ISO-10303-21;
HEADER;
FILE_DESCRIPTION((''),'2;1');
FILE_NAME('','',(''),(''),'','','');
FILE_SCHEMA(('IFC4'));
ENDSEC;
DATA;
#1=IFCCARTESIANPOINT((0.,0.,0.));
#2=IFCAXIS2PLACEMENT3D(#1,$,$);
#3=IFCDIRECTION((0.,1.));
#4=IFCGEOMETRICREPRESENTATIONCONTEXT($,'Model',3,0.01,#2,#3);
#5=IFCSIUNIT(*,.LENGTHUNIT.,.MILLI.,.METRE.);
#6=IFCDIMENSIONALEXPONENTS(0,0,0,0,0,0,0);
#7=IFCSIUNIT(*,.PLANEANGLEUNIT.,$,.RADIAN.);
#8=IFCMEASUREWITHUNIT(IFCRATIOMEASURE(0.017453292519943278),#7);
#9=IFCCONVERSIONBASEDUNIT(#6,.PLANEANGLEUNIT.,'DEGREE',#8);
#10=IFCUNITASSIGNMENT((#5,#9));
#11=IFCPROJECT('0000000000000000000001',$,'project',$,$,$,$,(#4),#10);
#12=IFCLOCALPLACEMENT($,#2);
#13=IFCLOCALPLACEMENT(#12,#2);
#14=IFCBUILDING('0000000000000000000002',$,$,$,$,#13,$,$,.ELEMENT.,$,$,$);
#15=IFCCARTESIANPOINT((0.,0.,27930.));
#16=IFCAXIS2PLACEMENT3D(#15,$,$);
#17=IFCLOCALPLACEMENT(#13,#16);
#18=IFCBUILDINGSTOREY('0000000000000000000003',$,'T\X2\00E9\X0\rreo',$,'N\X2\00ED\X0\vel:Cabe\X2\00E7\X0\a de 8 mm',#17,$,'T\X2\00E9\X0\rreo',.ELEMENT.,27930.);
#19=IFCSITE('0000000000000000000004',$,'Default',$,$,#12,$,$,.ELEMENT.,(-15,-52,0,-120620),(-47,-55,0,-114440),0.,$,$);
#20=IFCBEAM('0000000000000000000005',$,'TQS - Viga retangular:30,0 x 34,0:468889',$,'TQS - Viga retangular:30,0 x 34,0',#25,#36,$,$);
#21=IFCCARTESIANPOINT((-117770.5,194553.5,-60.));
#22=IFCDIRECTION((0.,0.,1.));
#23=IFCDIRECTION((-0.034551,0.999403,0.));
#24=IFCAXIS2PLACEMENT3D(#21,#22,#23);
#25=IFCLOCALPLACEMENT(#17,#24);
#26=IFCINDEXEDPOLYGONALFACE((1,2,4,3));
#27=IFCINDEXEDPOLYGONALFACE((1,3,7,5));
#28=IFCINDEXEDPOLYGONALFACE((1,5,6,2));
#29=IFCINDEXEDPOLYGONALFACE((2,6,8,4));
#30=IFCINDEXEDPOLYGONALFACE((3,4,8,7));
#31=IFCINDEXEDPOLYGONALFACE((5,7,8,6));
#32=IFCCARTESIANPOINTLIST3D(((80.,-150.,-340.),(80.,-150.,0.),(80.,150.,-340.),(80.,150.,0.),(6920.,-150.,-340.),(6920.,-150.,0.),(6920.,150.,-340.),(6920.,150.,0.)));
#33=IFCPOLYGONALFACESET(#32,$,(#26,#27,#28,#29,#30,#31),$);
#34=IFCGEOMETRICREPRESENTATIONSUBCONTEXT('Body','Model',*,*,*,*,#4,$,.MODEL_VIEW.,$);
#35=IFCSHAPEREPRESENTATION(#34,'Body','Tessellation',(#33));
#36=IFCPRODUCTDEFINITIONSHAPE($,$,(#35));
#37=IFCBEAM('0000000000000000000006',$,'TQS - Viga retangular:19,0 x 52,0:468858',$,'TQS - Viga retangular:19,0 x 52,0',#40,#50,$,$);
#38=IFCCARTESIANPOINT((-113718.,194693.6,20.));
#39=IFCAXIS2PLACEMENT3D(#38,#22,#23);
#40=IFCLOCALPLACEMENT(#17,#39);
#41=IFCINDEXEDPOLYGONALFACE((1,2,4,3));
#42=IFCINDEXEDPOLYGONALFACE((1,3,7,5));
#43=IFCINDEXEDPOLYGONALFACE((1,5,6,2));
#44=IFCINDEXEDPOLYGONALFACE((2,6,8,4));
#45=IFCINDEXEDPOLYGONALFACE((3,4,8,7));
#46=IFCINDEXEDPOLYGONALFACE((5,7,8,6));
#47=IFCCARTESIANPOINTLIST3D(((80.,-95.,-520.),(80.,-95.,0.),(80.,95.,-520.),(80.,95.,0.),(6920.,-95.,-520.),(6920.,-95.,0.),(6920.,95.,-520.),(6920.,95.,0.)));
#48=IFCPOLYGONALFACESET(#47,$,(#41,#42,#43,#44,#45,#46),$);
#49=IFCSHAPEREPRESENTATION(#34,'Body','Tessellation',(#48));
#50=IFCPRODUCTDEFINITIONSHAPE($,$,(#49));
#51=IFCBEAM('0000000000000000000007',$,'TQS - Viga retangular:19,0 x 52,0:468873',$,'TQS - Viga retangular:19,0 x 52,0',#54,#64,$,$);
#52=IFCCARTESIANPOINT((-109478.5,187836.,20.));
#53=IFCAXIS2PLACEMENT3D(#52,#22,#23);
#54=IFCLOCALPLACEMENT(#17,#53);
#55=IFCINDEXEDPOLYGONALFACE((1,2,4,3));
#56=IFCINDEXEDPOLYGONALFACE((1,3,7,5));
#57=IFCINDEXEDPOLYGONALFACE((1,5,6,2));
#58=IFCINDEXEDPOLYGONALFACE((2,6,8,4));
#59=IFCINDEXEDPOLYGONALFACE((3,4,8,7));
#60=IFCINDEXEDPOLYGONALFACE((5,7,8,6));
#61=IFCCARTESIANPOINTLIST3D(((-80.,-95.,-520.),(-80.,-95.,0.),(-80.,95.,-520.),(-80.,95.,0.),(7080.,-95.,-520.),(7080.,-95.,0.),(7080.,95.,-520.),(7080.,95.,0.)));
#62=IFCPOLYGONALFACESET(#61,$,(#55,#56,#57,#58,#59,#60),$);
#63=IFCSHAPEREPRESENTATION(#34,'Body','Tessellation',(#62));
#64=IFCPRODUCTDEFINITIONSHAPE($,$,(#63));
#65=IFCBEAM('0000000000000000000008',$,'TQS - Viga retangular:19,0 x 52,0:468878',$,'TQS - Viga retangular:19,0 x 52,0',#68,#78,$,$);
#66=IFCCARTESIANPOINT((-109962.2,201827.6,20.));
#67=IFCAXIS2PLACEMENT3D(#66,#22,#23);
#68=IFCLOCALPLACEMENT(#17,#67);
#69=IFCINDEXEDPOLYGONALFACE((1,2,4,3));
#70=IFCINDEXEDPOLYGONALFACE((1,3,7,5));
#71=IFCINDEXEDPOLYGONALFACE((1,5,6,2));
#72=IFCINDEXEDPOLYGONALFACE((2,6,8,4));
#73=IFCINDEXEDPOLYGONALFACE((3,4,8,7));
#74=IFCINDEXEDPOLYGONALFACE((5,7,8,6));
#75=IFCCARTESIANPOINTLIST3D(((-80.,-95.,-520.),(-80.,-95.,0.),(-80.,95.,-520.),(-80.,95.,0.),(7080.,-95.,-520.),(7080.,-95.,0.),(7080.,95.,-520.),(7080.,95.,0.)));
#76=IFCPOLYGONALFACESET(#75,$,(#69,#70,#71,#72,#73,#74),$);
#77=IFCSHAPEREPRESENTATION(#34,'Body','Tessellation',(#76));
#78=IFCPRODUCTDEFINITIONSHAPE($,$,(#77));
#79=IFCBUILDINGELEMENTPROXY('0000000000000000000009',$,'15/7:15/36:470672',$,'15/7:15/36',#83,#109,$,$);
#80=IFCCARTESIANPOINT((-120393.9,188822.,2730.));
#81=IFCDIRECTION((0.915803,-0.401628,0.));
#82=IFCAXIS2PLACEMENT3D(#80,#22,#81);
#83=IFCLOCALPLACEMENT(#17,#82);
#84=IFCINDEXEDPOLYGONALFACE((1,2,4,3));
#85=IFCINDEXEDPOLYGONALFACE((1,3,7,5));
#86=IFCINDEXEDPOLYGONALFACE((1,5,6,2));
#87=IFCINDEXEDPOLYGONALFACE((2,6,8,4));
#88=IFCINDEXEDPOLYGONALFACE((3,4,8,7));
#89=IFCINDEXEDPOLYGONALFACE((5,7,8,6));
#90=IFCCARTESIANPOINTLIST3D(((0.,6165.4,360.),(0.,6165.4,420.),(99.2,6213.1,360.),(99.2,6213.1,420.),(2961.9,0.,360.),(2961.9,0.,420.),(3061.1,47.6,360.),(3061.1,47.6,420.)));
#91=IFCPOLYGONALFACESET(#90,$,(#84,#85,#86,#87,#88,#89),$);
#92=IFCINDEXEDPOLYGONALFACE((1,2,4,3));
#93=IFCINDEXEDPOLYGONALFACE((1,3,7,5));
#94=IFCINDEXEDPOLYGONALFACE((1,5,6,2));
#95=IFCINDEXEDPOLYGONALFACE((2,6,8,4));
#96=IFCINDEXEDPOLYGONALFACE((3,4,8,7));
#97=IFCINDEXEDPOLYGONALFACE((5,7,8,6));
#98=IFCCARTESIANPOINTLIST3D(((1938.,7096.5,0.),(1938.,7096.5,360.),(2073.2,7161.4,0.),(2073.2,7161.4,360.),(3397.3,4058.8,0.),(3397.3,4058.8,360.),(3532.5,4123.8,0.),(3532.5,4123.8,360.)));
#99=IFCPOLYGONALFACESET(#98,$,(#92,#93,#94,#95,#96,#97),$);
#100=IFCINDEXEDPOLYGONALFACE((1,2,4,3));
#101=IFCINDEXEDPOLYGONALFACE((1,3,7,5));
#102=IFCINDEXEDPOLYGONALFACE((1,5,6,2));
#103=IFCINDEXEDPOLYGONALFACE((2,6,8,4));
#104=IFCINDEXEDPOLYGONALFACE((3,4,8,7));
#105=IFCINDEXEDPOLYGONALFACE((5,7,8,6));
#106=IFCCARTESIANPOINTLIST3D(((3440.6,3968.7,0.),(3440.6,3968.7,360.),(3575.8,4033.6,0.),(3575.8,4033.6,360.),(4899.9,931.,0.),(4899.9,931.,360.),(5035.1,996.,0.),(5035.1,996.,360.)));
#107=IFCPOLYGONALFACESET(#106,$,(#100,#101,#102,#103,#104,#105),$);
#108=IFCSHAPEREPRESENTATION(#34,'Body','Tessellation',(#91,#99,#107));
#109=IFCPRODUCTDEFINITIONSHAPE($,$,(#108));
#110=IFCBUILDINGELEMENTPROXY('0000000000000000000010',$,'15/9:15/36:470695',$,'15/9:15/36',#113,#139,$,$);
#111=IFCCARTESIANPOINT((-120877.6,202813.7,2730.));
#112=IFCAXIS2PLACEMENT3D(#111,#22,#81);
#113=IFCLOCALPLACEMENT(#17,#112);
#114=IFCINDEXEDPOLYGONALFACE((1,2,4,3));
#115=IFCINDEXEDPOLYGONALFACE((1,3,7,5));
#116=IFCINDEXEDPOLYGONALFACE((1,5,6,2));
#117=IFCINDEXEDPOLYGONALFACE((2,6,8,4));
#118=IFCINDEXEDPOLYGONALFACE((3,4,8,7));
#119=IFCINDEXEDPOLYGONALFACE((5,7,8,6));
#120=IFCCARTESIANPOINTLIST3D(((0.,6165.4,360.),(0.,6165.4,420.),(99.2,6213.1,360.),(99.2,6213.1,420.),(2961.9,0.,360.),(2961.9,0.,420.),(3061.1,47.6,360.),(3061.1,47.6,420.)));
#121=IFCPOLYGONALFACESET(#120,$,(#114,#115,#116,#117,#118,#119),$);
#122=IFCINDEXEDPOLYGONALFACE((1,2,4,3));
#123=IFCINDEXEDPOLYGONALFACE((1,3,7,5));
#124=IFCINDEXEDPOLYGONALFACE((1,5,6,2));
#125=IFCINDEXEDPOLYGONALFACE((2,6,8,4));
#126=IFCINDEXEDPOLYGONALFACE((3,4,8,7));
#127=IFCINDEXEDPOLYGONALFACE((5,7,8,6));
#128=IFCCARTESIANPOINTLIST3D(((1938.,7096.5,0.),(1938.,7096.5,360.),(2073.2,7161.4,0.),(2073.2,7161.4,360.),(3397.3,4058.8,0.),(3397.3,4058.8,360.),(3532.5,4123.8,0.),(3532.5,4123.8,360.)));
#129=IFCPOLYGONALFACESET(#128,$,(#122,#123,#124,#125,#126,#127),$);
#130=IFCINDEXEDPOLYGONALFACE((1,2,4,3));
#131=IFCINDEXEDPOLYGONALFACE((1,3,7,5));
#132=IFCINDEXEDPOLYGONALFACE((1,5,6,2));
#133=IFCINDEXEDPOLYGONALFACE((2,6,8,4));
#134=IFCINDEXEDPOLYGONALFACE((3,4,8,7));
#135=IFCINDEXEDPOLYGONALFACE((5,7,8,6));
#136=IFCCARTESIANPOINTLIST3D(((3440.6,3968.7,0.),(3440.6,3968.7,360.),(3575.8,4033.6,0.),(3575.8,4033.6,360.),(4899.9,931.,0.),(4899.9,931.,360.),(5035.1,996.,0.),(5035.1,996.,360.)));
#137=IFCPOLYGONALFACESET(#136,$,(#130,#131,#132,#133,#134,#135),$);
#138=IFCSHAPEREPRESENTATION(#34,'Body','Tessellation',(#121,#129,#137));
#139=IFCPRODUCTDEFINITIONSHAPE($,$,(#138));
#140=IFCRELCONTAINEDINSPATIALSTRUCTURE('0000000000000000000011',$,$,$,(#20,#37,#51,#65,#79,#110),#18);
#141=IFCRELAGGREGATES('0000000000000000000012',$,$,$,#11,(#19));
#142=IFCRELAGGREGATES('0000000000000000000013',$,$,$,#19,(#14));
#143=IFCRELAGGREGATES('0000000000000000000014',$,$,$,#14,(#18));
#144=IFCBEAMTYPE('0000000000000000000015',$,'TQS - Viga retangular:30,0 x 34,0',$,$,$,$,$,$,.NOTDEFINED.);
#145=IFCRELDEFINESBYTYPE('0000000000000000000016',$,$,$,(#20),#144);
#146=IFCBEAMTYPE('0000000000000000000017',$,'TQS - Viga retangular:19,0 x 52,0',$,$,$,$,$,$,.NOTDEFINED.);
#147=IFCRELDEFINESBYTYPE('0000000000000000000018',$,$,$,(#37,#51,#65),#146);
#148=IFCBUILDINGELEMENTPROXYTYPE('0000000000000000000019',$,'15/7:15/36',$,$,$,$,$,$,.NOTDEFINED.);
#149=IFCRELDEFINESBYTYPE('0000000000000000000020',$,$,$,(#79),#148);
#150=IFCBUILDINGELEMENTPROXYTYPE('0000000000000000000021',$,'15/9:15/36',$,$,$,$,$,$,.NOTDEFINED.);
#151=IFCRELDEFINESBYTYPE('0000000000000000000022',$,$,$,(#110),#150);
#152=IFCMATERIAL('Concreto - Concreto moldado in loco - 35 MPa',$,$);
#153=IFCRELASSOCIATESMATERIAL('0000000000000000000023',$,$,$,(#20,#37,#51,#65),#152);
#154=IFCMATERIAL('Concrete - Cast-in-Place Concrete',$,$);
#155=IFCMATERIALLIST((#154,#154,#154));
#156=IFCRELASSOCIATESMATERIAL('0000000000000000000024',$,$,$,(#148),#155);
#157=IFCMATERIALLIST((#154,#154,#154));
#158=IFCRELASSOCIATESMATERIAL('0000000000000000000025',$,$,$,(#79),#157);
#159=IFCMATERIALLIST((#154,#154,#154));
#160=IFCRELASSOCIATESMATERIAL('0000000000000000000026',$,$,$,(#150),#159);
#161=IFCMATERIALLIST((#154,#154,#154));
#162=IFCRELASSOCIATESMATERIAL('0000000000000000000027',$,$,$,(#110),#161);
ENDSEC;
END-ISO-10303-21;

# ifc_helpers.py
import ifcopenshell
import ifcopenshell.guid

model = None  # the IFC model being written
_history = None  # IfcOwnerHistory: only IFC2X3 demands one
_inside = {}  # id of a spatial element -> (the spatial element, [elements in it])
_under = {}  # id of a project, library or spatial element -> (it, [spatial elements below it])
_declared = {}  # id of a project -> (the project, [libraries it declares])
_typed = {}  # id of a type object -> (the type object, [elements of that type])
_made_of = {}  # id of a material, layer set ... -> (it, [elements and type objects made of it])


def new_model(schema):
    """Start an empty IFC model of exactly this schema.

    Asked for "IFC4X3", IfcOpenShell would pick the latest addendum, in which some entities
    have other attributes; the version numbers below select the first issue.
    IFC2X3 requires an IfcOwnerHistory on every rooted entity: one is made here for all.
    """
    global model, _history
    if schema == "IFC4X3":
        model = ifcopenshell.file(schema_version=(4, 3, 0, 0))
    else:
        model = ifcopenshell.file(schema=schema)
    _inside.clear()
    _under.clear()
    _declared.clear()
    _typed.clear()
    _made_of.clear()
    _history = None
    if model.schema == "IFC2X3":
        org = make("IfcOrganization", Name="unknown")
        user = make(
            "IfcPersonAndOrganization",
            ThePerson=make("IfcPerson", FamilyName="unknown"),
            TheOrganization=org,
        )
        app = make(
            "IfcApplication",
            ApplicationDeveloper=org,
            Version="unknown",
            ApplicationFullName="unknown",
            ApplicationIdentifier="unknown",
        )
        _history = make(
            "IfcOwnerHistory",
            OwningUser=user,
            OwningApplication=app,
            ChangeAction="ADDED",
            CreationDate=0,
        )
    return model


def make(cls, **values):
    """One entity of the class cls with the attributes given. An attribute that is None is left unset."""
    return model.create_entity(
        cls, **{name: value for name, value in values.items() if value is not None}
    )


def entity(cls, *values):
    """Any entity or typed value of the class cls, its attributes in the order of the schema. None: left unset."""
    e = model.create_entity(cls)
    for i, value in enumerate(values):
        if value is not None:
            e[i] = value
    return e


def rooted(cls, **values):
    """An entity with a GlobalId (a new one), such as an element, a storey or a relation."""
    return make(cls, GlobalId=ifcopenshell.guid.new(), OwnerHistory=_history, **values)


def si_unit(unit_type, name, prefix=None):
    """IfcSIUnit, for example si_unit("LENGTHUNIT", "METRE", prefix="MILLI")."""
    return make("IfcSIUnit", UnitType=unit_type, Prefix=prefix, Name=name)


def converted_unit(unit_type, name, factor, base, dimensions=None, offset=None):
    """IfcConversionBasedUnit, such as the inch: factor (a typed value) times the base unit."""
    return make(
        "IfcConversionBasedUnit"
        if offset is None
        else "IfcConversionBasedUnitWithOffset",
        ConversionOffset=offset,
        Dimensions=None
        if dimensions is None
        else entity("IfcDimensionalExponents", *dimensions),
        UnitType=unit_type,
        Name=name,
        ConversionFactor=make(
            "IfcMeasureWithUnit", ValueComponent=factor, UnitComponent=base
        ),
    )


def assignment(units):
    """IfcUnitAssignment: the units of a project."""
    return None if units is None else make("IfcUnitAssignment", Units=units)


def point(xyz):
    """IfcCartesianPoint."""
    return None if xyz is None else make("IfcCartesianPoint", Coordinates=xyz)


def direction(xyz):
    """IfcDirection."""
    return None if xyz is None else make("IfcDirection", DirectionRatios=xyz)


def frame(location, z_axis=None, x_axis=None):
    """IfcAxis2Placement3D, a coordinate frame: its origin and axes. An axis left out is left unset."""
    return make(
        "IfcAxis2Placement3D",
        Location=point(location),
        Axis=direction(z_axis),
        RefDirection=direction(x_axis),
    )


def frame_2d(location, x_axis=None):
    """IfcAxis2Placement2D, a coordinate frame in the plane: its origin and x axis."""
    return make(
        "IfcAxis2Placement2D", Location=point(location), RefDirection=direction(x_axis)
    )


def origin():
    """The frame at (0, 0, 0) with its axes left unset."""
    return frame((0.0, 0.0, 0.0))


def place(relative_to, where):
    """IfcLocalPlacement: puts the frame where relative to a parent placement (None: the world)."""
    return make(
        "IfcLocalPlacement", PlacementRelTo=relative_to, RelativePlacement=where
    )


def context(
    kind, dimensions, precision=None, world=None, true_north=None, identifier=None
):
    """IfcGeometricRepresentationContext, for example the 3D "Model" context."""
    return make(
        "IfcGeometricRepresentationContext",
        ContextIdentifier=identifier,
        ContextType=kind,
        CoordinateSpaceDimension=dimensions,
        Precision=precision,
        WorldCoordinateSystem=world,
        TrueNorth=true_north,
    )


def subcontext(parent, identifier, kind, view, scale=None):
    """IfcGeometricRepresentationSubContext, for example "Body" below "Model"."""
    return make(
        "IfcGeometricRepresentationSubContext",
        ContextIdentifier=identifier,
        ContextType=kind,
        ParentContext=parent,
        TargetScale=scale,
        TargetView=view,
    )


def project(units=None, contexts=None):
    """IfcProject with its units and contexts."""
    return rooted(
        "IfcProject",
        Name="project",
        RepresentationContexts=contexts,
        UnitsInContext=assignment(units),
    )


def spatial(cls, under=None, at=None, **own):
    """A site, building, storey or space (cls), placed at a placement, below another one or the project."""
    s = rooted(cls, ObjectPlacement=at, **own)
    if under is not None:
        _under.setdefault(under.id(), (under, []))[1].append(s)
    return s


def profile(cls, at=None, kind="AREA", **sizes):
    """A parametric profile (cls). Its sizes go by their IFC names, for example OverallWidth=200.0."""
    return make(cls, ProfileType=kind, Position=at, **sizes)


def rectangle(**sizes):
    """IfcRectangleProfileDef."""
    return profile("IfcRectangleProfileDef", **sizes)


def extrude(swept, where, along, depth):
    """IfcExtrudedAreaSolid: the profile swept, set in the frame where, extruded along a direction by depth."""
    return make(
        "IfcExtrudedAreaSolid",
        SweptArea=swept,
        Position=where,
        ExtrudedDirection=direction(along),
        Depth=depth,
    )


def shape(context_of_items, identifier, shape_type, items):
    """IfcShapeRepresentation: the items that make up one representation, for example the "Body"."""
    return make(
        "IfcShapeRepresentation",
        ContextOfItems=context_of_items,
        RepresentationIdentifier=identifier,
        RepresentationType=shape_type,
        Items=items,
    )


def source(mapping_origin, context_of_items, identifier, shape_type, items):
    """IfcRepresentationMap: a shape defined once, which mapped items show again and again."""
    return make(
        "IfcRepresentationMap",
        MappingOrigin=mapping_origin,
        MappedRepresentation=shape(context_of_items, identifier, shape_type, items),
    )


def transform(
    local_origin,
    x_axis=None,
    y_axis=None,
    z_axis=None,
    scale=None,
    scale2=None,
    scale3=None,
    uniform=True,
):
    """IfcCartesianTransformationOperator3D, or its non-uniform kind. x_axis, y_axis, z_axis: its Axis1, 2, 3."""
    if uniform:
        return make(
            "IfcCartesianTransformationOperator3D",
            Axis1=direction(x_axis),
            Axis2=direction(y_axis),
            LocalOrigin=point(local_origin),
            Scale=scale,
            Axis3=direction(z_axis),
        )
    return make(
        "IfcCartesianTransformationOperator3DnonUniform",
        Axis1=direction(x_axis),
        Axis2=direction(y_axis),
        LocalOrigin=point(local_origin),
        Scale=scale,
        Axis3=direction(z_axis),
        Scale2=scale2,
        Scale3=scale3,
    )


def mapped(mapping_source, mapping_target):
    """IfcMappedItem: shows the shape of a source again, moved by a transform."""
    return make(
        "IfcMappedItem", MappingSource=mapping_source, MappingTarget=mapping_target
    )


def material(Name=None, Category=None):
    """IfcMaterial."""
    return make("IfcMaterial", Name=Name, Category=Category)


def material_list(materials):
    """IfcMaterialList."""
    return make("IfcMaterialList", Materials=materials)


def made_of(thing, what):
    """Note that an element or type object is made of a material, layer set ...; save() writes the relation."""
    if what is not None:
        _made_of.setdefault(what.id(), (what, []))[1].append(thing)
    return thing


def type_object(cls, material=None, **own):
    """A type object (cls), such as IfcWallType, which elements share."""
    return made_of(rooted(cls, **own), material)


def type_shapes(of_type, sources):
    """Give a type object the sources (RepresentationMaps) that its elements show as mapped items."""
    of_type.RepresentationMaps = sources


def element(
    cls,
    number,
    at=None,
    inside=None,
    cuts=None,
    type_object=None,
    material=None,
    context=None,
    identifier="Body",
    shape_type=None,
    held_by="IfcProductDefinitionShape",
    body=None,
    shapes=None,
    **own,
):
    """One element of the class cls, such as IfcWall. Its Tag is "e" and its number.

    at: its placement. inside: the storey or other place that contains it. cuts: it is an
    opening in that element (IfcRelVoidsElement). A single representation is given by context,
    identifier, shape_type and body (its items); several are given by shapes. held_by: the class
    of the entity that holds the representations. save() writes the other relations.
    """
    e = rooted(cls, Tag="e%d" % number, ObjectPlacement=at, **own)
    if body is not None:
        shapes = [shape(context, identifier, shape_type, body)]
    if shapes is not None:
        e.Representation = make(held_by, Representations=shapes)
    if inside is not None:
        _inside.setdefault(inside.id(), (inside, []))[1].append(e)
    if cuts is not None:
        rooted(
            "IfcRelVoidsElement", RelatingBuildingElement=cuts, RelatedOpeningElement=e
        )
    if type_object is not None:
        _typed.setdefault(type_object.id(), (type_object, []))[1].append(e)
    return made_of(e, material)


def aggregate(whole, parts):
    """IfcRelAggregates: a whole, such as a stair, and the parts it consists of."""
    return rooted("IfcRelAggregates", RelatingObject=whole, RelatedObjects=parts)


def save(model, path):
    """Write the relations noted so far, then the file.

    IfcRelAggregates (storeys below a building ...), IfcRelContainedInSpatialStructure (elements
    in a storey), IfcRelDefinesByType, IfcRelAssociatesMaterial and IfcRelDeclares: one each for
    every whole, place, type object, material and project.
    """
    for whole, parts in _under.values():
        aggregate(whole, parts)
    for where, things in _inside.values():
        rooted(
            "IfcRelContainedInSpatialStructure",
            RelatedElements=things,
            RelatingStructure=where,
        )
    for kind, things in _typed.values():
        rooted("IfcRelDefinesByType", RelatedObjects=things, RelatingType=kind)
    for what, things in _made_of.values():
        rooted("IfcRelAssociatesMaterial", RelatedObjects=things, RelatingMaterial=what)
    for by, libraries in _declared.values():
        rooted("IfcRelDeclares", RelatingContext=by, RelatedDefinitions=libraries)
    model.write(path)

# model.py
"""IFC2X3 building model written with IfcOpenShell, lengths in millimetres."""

from ifc_helpers import new_model, entity, si_unit, converted_unit, direction, frame, frame_2d, origin, place, context, subcontext, project, spatial, rectangle, extrude, source, transform, mapped, material, material_list, type_object, type_shapes, element, save


model = new_model("IFC2X3")

# Units and contexts
model_context = context("Model", 3, precision=0.01, world=origin(), true_north=direction((0.0, 1.0)))
body_context = subcontext(model_context, "Body", "Model", "MODEL_VIEW")
ifc_project = project(units=[si_unit("LENGTHUNIT", "METRE", prefix="MILLI"), converted_unit("PLANEANGLEUNIT", "DEGREE", entity("IfcRatioMeasure", 0.017453292519943278), si_unit("PLANEANGLEUNIT", "RADIAN"), dimensions=[0, 0, 0, 0, 0, 0, 0])], contexts=[model_context])

# Site, building, storey
site_placement = place(None, origin())
site = spatial("IfcSite", under=ifc_project, at=site_placement, Name="Default", CompositionType="ELEMENT", RefLatitude=(-15, -52, 0, -120620), RefLongitude=(-47, -55, 0, -114440), RefElevation=0.0)
building_placement = place(site_placement, origin())
building = spatial("IfcBuilding", under=site, at=building_placement, CompositionType="ELEMENT")
storey_placement = place(building_placement, frame((0.0, 0.0, 27930.0)))
storey = spatial("IfcBuildingStorey", under=building, at=storey_placement, Name="Térreo", ObjectType="Nível:Cabeça de 8 mm", LongName="Térreo", CompositionType="ELEMENT", Elevation=27930.0)

# Beams
ifc_material_1 = material(Name="Concreto - Concreto moldado in loco - 35 MPa")
beam_type_1 = type_object("IfcBeamType", Name="TQS - Viga retangular:30,0 x 34,0", PredefinedType="NOTDEFINED")
beam_1_placement = place(storey_placement, frame((-117770.5, 194553.5, -60.0), z_axis=(0.0, 0.0, 1.0), x_axis=(-0.034551, 0.999403, 0.0)))
element("IfcBeam", 1, at=beam_1_placement, inside=storey, type_object=beam_type_1, material=ifc_material_1, Name="TQS - Viga retangular:30,0 x 34,0:468889", ObjectType="TQS - Viga retangular:30,0 x 34,0", context=body_context, shape_type="SweptSolid", body=[
    extrude(rectangle(XDim=340.0, YDim=300.0, at=frame_2d((0.0, 0.0), x_axis=(1.0, 0.0))), frame((80.0, 0.0, -170.0), z_axis=(1.0, 0.0, 0.0), x_axis=(0.0, 0.0, -1.0)), (0.0, 0.0, 1.0), 6840.0),
])
beam_type_2 = type_object("IfcBeamType", Name="TQS - Viga retangular:19,0 x 52,0", PredefinedType="NOTDEFINED")
beam_2_placement = place(storey_placement, frame((-113718.0, 194693.6, 20.0), z_axis=(0.0, 0.0, 1.0), x_axis=(-0.034551, 0.999403, 0.0)))
element("IfcBeam", 2, at=beam_2_placement, inside=storey, type_object=beam_type_2, material=ifc_material_1, Name="TQS - Viga retangular:19,0 x 52,0:468858", ObjectType="TQS - Viga retangular:19,0 x 52,0", context=body_context, shape_type="SweptSolid", body=[
    extrude(rectangle(XDim=520.0, YDim=190.0, at=frame_2d((0.0, 0.0), x_axis=(1.0, 0.0))), frame((80.0, 0.0, -260.0), z_axis=(1.0, 0.0, 0.0), x_axis=(0.0, 0.0, -1.0)), (0.0, 0.0, 1.0), 6840.0),
])
beam_3_placement = place(storey_placement, frame((-109478.5, 187836.0, 20.0), z_axis=(0.0, 0.0, 1.0), x_axis=(-0.034551, 0.999403, 0.0)))
element("IfcBeam", 3, at=beam_3_placement, inside=storey, type_object=beam_type_2, material=ifc_material_1, Name="TQS - Viga retangular:19,0 x 52,0:468873", ObjectType="TQS - Viga retangular:19,0 x 52,0", context=body_context, shape_type="SweptSolid", body=[
    extrude(rectangle(XDim=520.0, YDim=190.0, at=frame_2d((0.0, 0.0), x_axis=(1.0, 0.0))), frame((-80.0, 0.0, -260.0), z_axis=(1.0, 0.0, 0.0), x_axis=(0.0, 0.0, -1.0)), (0.0, 0.0, 1.0), 7160.0),
])
beam_4_placement = place(storey_placement, frame((-109962.2, 201827.6, 20.0), z_axis=(0.0, 0.0, 1.0), x_axis=(-0.034551, 0.999403, 0.0)))
element("IfcBeam", 4, at=beam_4_placement, inside=storey, type_object=beam_type_2, material=ifc_material_1, Name="TQS - Viga retangular:19,0 x 52,0:468878", ObjectType="TQS - Viga retangular:19,0 x 52,0", context=body_context, shape_type="SweptSolid", body=[
    extrude(rectangle(XDim=520.0, YDim=190.0, at=frame_2d((0.0, 0.0), x_axis=(1.0, 0.0))), frame((-80.0, 0.0, -260.0), z_axis=(1.0, 0.0, 0.0), x_axis=(0.0, 0.0, -1.0)), (0.0, 0.0, 1.0), 7160.0),
])

# Building element proxies
ifc_material_2 = material(Name="Concrete - Cast-in-Place Concrete")
ifc_material_list_1 = material_list([ifc_material_2, ifc_material_2, ifc_material_2])
ifc_material_list_2 = material_list([ifc_material_2, ifc_material_2, ifc_material_2])
building_element_proxy_type_1 = type_object("IfcBuildingElementProxyType", Name="15/7:15/36", PredefinedType="NOTDEFINED", material=ifc_material_list_2)
shared_shape_1 = source(origin(), body_context, "Body", "SweptSolid", [
    extrude(rectangle(XDim=110.0, YDim=6840.0, at=frame_2d((0.0, 0.0), x_axis=(1.0, 0.0))), frame((1530.5, 3106.5, 360.0), z_axis=(0.0, 0.0, 1.0), x_axis=(0.90138, 0.43303, 0.0)), (0.0, 0.0, 1.0), 60.0),
    extrude(rectangle(XDim=3370.0, YDim=150.0, at=frame_2d((0.0, 0.0), x_axis=(1.0, 0.0))), frame((2735.2, 5610.1, 0.0), z_axis=(0.0, 0.0, 1.0), x_axis=(0.43303, -0.90138, 0.0)), (0.0, 0.0, 1.0), 360.0),
    extrude(rectangle(XDim=3370.0, YDim=150.0, at=frame_2d((0.0, 0.0), x_axis=(1.0, 0.0))), frame((4237.8, 2482.3, 0.0), z_axis=(0.0, 0.0, 1.0), x_axis=(0.43303, -0.90138, 0.0)), (0.0, 0.0, 1.0), 360.0),
])
type_shapes(building_element_proxy_type_1, [shared_shape_1])
proxy_1_placement = place(storey_placement, frame((-120393.9, 188822.0, 2730.0), z_axis=(0.0, 0.0, 1.0), x_axis=(0.915803, -0.401628, 0.0)))
element("IfcBuildingElementProxy", 5, at=proxy_1_placement, inside=storey, type_object=building_element_proxy_type_1, material=ifc_material_list_1, Name="15/7:15/36:470672", ObjectType="15/7:15/36", context=body_context, shape_type="MappedRepresentation", body=[
    mapped(shared_shape_1, transform((0.0, 0.0, 0.0), scale=1.0)),
])
ifc_material_list_3 = material_list([ifc_material_2, ifc_material_2, ifc_material_2])
ifc_material_list_4 = material_list([ifc_material_2, ifc_material_2, ifc_material_2])
building_element_proxy_type_2 = type_object("IfcBuildingElementProxyType", Name="15/9:15/36", PredefinedType="NOTDEFINED", material=ifc_material_list_4)
shared_shape_2 = source(origin(), body_context, "Body", "SweptSolid", [
    extrude(rectangle(XDim=110.0, YDim=6840.0, at=frame_2d((0.0, 0.0), x_axis=(1.0, 0.0))), frame((1530.5, 3106.5, 360.0), z_axis=(0.0, 0.0, 1.0), x_axis=(0.90138, 0.43303, 0.0)), (0.0, 0.0, 1.0), 60.0),
    extrude(rectangle(XDim=3370.0, YDim=150.0, at=frame_2d((0.0, 0.0), x_axis=(1.0, 0.0))), frame((2735.2, 5610.1, 0.0), z_axis=(0.0, 0.0, 1.0), x_axis=(0.43303, -0.90138, 0.0)), (0.0, 0.0, 1.0), 360.0),
    extrude(rectangle(XDim=3370.0, YDim=150.0, at=frame_2d((0.0, 0.0), x_axis=(1.0, 0.0))), frame((4237.8, 2482.3, 0.0), z_axis=(0.0, 0.0, 1.0), x_axis=(0.43303, -0.90138, 0.0)), (0.0, 0.0, 1.0), 360.0),
])
type_shapes(building_element_proxy_type_2, [shared_shape_2])
proxy_2_placement = place(storey_placement, frame((-120877.6, 202813.7, 2730.0), z_axis=(0.0, 0.0, 1.0), x_axis=(0.915803, -0.401628, 0.0)))
element("IfcBuildingElementProxy", 6, at=proxy_2_placement, inside=storey, type_object=building_element_proxy_type_2, material=ifc_material_list_3, Name="15/9:15/36:470695", ObjectType="15/9:15/36", context=body_context, shape_type="MappedRepresentation", body=[
    mapped(shared_shape_2, transform((0.0, 0.0, 0.0), scale=1.0)),
])

save(model, "model.ifc")
